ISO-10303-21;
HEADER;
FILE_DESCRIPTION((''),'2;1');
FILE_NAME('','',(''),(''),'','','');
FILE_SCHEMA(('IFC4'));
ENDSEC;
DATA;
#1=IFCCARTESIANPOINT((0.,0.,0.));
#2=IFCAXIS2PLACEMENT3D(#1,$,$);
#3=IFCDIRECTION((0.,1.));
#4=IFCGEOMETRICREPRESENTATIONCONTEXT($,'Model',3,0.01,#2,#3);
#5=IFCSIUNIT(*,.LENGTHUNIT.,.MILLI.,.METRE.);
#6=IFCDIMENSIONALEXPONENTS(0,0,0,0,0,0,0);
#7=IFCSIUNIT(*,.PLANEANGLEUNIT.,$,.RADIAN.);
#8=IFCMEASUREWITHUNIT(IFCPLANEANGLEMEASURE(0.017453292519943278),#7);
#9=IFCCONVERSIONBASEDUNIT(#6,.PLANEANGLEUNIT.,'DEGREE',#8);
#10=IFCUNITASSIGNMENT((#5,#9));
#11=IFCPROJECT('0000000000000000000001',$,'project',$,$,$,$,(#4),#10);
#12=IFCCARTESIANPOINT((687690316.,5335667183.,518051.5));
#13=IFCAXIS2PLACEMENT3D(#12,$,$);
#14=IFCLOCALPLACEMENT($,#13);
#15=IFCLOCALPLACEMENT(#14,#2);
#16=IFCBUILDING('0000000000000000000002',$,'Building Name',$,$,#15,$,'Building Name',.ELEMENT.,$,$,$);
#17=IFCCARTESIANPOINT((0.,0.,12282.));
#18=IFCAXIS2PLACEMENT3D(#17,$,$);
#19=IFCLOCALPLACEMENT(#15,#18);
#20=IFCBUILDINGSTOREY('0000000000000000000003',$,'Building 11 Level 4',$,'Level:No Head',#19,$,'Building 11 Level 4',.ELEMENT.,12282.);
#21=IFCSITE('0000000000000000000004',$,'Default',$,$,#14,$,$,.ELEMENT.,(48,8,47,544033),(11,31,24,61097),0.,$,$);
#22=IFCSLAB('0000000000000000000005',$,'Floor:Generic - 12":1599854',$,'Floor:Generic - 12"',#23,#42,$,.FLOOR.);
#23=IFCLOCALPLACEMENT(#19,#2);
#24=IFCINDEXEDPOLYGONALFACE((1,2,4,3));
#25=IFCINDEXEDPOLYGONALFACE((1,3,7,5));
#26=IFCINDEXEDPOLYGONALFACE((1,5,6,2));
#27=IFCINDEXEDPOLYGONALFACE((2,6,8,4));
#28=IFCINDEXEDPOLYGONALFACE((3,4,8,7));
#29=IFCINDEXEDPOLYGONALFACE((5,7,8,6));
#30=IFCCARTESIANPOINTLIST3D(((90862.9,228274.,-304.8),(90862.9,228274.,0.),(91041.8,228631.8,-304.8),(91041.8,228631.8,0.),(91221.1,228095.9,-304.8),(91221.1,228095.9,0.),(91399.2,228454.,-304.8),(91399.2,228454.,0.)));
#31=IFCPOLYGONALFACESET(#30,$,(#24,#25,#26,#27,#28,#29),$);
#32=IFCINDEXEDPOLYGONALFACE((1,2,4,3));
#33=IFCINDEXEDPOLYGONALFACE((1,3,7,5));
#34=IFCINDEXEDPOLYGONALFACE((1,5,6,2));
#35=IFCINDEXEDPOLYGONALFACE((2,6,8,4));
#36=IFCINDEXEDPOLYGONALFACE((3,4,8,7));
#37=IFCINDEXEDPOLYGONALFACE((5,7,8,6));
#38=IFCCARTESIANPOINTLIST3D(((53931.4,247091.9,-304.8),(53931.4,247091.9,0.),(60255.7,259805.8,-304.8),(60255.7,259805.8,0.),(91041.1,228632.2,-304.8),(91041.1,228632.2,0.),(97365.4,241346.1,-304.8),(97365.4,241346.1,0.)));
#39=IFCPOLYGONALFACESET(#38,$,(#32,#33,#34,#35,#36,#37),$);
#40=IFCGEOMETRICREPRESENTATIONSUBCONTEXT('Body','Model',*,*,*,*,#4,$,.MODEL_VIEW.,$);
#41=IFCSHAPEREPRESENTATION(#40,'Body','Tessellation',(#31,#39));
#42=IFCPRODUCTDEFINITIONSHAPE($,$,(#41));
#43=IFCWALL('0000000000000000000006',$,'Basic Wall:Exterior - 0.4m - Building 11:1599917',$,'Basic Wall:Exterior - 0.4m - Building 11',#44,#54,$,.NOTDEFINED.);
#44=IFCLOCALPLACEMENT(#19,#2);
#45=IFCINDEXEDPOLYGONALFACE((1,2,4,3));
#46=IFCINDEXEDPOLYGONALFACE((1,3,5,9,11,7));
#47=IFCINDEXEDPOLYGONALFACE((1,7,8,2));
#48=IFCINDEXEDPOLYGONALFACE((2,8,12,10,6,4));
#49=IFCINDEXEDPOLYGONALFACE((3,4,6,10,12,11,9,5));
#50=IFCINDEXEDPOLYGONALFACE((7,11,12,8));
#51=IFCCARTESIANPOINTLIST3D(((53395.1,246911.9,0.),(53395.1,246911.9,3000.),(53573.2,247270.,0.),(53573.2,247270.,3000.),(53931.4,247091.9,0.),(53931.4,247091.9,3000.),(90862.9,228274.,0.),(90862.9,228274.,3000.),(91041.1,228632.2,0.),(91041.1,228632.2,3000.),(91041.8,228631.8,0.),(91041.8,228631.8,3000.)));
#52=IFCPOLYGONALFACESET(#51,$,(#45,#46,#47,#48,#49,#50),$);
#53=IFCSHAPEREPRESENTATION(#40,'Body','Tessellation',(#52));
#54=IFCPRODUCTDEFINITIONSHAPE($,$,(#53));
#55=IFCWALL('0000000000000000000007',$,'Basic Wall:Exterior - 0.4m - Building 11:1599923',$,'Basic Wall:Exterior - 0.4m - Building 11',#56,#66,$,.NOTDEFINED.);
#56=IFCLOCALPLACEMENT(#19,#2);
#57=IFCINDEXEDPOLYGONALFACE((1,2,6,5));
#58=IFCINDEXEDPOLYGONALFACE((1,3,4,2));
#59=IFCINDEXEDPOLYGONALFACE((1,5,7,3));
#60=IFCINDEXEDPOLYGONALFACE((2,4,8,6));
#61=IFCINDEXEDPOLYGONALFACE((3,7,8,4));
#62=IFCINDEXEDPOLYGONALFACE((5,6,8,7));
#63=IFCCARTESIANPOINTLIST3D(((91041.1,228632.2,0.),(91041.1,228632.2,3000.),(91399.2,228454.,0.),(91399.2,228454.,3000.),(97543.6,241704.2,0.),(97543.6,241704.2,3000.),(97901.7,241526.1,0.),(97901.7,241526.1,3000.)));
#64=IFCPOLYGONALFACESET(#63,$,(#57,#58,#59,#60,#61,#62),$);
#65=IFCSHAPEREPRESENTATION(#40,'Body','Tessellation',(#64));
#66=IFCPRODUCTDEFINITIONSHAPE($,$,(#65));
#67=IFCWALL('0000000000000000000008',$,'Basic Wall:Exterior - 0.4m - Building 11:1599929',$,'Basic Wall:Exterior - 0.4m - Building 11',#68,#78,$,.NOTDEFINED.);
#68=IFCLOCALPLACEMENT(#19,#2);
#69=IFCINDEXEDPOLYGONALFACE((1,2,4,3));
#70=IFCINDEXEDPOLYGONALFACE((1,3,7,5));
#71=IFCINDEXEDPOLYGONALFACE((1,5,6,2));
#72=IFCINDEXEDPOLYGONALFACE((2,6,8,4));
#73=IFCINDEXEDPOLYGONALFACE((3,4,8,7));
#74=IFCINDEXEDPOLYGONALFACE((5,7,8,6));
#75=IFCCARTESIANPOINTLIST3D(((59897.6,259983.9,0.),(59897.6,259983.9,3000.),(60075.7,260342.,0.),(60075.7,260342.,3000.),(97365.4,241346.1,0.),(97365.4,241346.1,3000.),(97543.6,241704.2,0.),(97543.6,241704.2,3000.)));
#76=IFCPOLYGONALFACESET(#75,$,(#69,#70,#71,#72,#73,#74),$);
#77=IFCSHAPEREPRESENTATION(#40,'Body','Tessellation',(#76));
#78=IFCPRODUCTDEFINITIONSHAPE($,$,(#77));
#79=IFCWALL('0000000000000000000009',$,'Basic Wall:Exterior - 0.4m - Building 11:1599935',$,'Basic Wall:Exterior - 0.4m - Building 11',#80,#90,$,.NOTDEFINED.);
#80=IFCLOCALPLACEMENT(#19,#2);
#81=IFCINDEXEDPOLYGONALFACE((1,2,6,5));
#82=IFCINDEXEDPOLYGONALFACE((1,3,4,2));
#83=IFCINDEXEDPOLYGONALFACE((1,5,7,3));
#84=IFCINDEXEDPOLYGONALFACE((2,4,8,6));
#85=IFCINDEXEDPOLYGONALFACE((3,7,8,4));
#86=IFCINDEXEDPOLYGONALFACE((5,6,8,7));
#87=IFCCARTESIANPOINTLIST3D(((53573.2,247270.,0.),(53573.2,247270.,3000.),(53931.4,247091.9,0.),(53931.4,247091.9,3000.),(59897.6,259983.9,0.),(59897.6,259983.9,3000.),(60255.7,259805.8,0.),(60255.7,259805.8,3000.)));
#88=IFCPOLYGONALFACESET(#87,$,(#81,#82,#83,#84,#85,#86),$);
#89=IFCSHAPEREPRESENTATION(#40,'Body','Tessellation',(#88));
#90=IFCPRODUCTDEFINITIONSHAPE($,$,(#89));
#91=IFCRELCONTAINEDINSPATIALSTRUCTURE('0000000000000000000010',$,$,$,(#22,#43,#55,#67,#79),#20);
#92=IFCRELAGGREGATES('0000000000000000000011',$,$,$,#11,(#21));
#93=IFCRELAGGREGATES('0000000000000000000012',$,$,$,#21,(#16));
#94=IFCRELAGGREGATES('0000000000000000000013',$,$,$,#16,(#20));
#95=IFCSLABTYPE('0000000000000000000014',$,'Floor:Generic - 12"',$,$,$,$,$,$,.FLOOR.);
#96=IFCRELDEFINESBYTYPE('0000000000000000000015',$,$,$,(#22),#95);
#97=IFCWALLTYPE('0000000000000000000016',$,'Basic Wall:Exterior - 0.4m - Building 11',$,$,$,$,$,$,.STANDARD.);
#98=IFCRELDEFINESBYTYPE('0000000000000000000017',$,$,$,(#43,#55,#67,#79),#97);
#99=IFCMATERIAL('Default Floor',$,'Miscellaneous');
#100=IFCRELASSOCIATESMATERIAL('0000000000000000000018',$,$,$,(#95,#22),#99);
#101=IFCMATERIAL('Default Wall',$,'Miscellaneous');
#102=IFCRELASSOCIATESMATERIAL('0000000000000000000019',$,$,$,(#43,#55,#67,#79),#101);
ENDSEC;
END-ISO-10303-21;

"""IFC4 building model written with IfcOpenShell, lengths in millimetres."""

from ifc_helpers import new_model, entity, si_unit, converted_unit, direction, frame, origin, place, context, subcontext, project, spatial, indexed_curve, outline, extrude, material, type_object, element, save


model = new_model("IFC4")

# Units and contexts
model_context = context("Model", 3, precision=0.01, world=origin(), true_north=direction((0.0, 1.0)))
body_context = subcontext(model_context, "Body", "Model", "MODEL_VIEW")
ifc_project = project(units=[si_unit("LENGTHUNIT", "METRE", prefix="MILLI"), converted_unit("PLANEANGLEUNIT", "DEGREE", entity("IfcPlaneAngleMeasure", 0.017453292519943278), si_unit("PLANEANGLEUNIT", "RADIAN"), dimensions=[0, 0, 0, 0, 0, 0, 0])], contexts=[model_context])

# Site, building, storey
site_placement = place(None, frame((687690316.0, 5335667183.0, 518051.5)))
site = spatial("IfcSite", under=ifc_project, at=site_placement, Name="Default", CompositionType="ELEMENT", RefLatitude=(48, 8, 47, 544033), RefLongitude=(11, 31, 24, 61097), RefElevation=0.0)
building_placement = place(site_placement, origin())
building = spatial("IfcBuilding", under=site, at=building_placement, Name="Building Name", LongName="Building Name", CompositionType="ELEMENT")
storey_placement = place(building_placement, frame((0.0, 0.0, 12282.0)))
storey = spatial("IfcBuildingStorey", under=building, at=storey_placement, Name="Building 11 Level 4", ObjectType="Level:No Head", LongName="Building 11 Level 4", CompositionType="ELEMENT", Elevation=12282.0)

# Slab
ifc_material_1 = material(Name="Default Floor", Category="Miscellaneous")
slab_type = type_object("IfcSlabType", Name="Floor:Generic - 12\"", PredefinedType="FLOOR", material=ifc_material_1)
slab_placement = place(storey_placement, origin())
element("IfcSlab", 1, at=slab_placement, inside=storey, type_object=slab_type, material=ifc_material_1, Name="Floor:Generic - 12\":1599854", ObjectType="Floor:Generic - 12\"", PredefinedType="FLOOR", context=body_context, shape_type="SweptSolid", body=[
    extrude(outline(indexed_curve([(-199.6, -199.8), (200.4, -199.8), (199.6, 200.2), (-200.4, 199.4), (-199.6, -199.8)], self_intersect=False)), frame((91131.2, 228363.9, -304.8), z_axis=(0.0, 0.0, 1.0), x_axis=(-0.447226, -0.894421, 0.0)), (0.0, 0.0, 1.0), 304.8),
    extrude(outline(indexed_curve([(-20723.7, -7100.0), (20723.7, -7100.0), (20723.7, 7100.0), (-20723.7, 7100.0), (-20723.7, -7100.0)], self_intersect=False)), frame((75648.4, 244219.0, -304.8), z_axis=(0.0, 0.0, 1.0), x_axis=(-0.895344, 0.445376, 0.0)), (0.0, 0.0, 1.0), 304.8),
])

# Walls
ifc_material_2 = material(Name="Default Wall", Category="Miscellaneous")
wall_type = type_object("IfcWallType", Name="Basic Wall:Exterior - 0.4m - Building 11", PredefinedType="STANDARD")
wall_1_placement = place(storey_placement, frame((53484.2, 247091.0, 0.0), z_axis=(0.0, 0.0, 1.0), x_axis=(0.895344, -0.445376, 0.0)))
element("IfcWall", 2, at=wall_1_placement, inside=storey, type_object=wall_type, material=ifc_material_2, Name="Basic Wall:Exterior - 0.4m - Building 11:1599917", ObjectType="Basic Wall:Exterior - 0.4m - Building 11", PredefinedType="NOTDEFINED", context=body_context, shape_type="SweptSolid", body=[
    extrude(outline(indexed_curve([(41847.4, -200.0), (41848.3, 200.0), (41847.4, 200.0), (400.0, 200.0), (0.0, 200.0), (0.0, -200.0), (41847.4, -200.0)], self_intersect=False)), origin(), (0.0, 0.0, 1.0), 3000.0),
])
wall_2_placement = place(storey_placement, frame((91220.1, 228543.1, 0.0), z_axis=(0.0, 0.0, 1.0), x_axis=(0.445376, 0.895344, 0.0)))
element("IfcWall", 3, at=wall_2_placement, inside=storey, type_object=wall_type, material=ifc_material_2, Name="Basic Wall:Exterior - 0.4m - Building 11:1599923", ObjectType="Basic Wall:Exterior - 0.4m - Building 11", PredefinedType="NOTDEFINED", context=body_context, shape_type="SweptSolid", body=[
    extrude(outline(indexed_curve([(14600.0, 200.0), (0.0, 200.0), (0.0, -200.0), (14600.0, -200.0), (14600.0, 200.0)], self_intersect=False)), origin(), (0.0, 0.0, 1.0), 3000.0),
])
wall_3_placement = place(storey_placement, frame((97454.5, 241525.1, 0.0), z_axis=(0.0, 0.0, 1.0), x_axis=(-0.895344, 0.445376, 0.0)))
element("IfcWall", 4, at=wall_3_placement, inside=storey, type_object=wall_type, material=ifc_material_2, Name="Basic Wall:Exterior - 0.4m - Building 11:1599929", ObjectType="Basic Wall:Exterior - 0.4m - Building 11", PredefinedType="NOTDEFINED", context=body_context, shape_type="SweptSolid", body=[
    extrude(outline(indexed_curve([(41847.4, 200.0), (0.0, 200.0), (0.0, -200.0), (41847.4, -200.0), (41847.4, 200.0)], self_intersect=False)), origin(), (0.0, 0.0, 1.0), 3000.0),
])
wall_4_placement = place(storey_placement, frame((60076.6, 259894.8, 0.0), z_axis=(0.0, 0.0, 1.0), x_axis=(-0.445376, -0.895344, 0.0)))
element("IfcWall", 5, at=wall_4_placement, inside=storey, type_object=wall_type, material=ifc_material_2, Name="Basic Wall:Exterior - 0.4m - Building 11:1599935", ObjectType="Basic Wall:Exterior - 0.4m - Building 11", PredefinedType="NOTDEFINED", context=body_context, shape_type="SweptSolid", body=[
    extrude(outline(indexed_curve([(14200.0, 200.0), (0.0, 200.0), (0.0, -200.0), (14200.0, -200.0), (14200.0, 200.0)], self_intersect=False)), origin(), (0.0, 0.0, 1.0), 3000.0),
])

save(model, "model.ifc")
